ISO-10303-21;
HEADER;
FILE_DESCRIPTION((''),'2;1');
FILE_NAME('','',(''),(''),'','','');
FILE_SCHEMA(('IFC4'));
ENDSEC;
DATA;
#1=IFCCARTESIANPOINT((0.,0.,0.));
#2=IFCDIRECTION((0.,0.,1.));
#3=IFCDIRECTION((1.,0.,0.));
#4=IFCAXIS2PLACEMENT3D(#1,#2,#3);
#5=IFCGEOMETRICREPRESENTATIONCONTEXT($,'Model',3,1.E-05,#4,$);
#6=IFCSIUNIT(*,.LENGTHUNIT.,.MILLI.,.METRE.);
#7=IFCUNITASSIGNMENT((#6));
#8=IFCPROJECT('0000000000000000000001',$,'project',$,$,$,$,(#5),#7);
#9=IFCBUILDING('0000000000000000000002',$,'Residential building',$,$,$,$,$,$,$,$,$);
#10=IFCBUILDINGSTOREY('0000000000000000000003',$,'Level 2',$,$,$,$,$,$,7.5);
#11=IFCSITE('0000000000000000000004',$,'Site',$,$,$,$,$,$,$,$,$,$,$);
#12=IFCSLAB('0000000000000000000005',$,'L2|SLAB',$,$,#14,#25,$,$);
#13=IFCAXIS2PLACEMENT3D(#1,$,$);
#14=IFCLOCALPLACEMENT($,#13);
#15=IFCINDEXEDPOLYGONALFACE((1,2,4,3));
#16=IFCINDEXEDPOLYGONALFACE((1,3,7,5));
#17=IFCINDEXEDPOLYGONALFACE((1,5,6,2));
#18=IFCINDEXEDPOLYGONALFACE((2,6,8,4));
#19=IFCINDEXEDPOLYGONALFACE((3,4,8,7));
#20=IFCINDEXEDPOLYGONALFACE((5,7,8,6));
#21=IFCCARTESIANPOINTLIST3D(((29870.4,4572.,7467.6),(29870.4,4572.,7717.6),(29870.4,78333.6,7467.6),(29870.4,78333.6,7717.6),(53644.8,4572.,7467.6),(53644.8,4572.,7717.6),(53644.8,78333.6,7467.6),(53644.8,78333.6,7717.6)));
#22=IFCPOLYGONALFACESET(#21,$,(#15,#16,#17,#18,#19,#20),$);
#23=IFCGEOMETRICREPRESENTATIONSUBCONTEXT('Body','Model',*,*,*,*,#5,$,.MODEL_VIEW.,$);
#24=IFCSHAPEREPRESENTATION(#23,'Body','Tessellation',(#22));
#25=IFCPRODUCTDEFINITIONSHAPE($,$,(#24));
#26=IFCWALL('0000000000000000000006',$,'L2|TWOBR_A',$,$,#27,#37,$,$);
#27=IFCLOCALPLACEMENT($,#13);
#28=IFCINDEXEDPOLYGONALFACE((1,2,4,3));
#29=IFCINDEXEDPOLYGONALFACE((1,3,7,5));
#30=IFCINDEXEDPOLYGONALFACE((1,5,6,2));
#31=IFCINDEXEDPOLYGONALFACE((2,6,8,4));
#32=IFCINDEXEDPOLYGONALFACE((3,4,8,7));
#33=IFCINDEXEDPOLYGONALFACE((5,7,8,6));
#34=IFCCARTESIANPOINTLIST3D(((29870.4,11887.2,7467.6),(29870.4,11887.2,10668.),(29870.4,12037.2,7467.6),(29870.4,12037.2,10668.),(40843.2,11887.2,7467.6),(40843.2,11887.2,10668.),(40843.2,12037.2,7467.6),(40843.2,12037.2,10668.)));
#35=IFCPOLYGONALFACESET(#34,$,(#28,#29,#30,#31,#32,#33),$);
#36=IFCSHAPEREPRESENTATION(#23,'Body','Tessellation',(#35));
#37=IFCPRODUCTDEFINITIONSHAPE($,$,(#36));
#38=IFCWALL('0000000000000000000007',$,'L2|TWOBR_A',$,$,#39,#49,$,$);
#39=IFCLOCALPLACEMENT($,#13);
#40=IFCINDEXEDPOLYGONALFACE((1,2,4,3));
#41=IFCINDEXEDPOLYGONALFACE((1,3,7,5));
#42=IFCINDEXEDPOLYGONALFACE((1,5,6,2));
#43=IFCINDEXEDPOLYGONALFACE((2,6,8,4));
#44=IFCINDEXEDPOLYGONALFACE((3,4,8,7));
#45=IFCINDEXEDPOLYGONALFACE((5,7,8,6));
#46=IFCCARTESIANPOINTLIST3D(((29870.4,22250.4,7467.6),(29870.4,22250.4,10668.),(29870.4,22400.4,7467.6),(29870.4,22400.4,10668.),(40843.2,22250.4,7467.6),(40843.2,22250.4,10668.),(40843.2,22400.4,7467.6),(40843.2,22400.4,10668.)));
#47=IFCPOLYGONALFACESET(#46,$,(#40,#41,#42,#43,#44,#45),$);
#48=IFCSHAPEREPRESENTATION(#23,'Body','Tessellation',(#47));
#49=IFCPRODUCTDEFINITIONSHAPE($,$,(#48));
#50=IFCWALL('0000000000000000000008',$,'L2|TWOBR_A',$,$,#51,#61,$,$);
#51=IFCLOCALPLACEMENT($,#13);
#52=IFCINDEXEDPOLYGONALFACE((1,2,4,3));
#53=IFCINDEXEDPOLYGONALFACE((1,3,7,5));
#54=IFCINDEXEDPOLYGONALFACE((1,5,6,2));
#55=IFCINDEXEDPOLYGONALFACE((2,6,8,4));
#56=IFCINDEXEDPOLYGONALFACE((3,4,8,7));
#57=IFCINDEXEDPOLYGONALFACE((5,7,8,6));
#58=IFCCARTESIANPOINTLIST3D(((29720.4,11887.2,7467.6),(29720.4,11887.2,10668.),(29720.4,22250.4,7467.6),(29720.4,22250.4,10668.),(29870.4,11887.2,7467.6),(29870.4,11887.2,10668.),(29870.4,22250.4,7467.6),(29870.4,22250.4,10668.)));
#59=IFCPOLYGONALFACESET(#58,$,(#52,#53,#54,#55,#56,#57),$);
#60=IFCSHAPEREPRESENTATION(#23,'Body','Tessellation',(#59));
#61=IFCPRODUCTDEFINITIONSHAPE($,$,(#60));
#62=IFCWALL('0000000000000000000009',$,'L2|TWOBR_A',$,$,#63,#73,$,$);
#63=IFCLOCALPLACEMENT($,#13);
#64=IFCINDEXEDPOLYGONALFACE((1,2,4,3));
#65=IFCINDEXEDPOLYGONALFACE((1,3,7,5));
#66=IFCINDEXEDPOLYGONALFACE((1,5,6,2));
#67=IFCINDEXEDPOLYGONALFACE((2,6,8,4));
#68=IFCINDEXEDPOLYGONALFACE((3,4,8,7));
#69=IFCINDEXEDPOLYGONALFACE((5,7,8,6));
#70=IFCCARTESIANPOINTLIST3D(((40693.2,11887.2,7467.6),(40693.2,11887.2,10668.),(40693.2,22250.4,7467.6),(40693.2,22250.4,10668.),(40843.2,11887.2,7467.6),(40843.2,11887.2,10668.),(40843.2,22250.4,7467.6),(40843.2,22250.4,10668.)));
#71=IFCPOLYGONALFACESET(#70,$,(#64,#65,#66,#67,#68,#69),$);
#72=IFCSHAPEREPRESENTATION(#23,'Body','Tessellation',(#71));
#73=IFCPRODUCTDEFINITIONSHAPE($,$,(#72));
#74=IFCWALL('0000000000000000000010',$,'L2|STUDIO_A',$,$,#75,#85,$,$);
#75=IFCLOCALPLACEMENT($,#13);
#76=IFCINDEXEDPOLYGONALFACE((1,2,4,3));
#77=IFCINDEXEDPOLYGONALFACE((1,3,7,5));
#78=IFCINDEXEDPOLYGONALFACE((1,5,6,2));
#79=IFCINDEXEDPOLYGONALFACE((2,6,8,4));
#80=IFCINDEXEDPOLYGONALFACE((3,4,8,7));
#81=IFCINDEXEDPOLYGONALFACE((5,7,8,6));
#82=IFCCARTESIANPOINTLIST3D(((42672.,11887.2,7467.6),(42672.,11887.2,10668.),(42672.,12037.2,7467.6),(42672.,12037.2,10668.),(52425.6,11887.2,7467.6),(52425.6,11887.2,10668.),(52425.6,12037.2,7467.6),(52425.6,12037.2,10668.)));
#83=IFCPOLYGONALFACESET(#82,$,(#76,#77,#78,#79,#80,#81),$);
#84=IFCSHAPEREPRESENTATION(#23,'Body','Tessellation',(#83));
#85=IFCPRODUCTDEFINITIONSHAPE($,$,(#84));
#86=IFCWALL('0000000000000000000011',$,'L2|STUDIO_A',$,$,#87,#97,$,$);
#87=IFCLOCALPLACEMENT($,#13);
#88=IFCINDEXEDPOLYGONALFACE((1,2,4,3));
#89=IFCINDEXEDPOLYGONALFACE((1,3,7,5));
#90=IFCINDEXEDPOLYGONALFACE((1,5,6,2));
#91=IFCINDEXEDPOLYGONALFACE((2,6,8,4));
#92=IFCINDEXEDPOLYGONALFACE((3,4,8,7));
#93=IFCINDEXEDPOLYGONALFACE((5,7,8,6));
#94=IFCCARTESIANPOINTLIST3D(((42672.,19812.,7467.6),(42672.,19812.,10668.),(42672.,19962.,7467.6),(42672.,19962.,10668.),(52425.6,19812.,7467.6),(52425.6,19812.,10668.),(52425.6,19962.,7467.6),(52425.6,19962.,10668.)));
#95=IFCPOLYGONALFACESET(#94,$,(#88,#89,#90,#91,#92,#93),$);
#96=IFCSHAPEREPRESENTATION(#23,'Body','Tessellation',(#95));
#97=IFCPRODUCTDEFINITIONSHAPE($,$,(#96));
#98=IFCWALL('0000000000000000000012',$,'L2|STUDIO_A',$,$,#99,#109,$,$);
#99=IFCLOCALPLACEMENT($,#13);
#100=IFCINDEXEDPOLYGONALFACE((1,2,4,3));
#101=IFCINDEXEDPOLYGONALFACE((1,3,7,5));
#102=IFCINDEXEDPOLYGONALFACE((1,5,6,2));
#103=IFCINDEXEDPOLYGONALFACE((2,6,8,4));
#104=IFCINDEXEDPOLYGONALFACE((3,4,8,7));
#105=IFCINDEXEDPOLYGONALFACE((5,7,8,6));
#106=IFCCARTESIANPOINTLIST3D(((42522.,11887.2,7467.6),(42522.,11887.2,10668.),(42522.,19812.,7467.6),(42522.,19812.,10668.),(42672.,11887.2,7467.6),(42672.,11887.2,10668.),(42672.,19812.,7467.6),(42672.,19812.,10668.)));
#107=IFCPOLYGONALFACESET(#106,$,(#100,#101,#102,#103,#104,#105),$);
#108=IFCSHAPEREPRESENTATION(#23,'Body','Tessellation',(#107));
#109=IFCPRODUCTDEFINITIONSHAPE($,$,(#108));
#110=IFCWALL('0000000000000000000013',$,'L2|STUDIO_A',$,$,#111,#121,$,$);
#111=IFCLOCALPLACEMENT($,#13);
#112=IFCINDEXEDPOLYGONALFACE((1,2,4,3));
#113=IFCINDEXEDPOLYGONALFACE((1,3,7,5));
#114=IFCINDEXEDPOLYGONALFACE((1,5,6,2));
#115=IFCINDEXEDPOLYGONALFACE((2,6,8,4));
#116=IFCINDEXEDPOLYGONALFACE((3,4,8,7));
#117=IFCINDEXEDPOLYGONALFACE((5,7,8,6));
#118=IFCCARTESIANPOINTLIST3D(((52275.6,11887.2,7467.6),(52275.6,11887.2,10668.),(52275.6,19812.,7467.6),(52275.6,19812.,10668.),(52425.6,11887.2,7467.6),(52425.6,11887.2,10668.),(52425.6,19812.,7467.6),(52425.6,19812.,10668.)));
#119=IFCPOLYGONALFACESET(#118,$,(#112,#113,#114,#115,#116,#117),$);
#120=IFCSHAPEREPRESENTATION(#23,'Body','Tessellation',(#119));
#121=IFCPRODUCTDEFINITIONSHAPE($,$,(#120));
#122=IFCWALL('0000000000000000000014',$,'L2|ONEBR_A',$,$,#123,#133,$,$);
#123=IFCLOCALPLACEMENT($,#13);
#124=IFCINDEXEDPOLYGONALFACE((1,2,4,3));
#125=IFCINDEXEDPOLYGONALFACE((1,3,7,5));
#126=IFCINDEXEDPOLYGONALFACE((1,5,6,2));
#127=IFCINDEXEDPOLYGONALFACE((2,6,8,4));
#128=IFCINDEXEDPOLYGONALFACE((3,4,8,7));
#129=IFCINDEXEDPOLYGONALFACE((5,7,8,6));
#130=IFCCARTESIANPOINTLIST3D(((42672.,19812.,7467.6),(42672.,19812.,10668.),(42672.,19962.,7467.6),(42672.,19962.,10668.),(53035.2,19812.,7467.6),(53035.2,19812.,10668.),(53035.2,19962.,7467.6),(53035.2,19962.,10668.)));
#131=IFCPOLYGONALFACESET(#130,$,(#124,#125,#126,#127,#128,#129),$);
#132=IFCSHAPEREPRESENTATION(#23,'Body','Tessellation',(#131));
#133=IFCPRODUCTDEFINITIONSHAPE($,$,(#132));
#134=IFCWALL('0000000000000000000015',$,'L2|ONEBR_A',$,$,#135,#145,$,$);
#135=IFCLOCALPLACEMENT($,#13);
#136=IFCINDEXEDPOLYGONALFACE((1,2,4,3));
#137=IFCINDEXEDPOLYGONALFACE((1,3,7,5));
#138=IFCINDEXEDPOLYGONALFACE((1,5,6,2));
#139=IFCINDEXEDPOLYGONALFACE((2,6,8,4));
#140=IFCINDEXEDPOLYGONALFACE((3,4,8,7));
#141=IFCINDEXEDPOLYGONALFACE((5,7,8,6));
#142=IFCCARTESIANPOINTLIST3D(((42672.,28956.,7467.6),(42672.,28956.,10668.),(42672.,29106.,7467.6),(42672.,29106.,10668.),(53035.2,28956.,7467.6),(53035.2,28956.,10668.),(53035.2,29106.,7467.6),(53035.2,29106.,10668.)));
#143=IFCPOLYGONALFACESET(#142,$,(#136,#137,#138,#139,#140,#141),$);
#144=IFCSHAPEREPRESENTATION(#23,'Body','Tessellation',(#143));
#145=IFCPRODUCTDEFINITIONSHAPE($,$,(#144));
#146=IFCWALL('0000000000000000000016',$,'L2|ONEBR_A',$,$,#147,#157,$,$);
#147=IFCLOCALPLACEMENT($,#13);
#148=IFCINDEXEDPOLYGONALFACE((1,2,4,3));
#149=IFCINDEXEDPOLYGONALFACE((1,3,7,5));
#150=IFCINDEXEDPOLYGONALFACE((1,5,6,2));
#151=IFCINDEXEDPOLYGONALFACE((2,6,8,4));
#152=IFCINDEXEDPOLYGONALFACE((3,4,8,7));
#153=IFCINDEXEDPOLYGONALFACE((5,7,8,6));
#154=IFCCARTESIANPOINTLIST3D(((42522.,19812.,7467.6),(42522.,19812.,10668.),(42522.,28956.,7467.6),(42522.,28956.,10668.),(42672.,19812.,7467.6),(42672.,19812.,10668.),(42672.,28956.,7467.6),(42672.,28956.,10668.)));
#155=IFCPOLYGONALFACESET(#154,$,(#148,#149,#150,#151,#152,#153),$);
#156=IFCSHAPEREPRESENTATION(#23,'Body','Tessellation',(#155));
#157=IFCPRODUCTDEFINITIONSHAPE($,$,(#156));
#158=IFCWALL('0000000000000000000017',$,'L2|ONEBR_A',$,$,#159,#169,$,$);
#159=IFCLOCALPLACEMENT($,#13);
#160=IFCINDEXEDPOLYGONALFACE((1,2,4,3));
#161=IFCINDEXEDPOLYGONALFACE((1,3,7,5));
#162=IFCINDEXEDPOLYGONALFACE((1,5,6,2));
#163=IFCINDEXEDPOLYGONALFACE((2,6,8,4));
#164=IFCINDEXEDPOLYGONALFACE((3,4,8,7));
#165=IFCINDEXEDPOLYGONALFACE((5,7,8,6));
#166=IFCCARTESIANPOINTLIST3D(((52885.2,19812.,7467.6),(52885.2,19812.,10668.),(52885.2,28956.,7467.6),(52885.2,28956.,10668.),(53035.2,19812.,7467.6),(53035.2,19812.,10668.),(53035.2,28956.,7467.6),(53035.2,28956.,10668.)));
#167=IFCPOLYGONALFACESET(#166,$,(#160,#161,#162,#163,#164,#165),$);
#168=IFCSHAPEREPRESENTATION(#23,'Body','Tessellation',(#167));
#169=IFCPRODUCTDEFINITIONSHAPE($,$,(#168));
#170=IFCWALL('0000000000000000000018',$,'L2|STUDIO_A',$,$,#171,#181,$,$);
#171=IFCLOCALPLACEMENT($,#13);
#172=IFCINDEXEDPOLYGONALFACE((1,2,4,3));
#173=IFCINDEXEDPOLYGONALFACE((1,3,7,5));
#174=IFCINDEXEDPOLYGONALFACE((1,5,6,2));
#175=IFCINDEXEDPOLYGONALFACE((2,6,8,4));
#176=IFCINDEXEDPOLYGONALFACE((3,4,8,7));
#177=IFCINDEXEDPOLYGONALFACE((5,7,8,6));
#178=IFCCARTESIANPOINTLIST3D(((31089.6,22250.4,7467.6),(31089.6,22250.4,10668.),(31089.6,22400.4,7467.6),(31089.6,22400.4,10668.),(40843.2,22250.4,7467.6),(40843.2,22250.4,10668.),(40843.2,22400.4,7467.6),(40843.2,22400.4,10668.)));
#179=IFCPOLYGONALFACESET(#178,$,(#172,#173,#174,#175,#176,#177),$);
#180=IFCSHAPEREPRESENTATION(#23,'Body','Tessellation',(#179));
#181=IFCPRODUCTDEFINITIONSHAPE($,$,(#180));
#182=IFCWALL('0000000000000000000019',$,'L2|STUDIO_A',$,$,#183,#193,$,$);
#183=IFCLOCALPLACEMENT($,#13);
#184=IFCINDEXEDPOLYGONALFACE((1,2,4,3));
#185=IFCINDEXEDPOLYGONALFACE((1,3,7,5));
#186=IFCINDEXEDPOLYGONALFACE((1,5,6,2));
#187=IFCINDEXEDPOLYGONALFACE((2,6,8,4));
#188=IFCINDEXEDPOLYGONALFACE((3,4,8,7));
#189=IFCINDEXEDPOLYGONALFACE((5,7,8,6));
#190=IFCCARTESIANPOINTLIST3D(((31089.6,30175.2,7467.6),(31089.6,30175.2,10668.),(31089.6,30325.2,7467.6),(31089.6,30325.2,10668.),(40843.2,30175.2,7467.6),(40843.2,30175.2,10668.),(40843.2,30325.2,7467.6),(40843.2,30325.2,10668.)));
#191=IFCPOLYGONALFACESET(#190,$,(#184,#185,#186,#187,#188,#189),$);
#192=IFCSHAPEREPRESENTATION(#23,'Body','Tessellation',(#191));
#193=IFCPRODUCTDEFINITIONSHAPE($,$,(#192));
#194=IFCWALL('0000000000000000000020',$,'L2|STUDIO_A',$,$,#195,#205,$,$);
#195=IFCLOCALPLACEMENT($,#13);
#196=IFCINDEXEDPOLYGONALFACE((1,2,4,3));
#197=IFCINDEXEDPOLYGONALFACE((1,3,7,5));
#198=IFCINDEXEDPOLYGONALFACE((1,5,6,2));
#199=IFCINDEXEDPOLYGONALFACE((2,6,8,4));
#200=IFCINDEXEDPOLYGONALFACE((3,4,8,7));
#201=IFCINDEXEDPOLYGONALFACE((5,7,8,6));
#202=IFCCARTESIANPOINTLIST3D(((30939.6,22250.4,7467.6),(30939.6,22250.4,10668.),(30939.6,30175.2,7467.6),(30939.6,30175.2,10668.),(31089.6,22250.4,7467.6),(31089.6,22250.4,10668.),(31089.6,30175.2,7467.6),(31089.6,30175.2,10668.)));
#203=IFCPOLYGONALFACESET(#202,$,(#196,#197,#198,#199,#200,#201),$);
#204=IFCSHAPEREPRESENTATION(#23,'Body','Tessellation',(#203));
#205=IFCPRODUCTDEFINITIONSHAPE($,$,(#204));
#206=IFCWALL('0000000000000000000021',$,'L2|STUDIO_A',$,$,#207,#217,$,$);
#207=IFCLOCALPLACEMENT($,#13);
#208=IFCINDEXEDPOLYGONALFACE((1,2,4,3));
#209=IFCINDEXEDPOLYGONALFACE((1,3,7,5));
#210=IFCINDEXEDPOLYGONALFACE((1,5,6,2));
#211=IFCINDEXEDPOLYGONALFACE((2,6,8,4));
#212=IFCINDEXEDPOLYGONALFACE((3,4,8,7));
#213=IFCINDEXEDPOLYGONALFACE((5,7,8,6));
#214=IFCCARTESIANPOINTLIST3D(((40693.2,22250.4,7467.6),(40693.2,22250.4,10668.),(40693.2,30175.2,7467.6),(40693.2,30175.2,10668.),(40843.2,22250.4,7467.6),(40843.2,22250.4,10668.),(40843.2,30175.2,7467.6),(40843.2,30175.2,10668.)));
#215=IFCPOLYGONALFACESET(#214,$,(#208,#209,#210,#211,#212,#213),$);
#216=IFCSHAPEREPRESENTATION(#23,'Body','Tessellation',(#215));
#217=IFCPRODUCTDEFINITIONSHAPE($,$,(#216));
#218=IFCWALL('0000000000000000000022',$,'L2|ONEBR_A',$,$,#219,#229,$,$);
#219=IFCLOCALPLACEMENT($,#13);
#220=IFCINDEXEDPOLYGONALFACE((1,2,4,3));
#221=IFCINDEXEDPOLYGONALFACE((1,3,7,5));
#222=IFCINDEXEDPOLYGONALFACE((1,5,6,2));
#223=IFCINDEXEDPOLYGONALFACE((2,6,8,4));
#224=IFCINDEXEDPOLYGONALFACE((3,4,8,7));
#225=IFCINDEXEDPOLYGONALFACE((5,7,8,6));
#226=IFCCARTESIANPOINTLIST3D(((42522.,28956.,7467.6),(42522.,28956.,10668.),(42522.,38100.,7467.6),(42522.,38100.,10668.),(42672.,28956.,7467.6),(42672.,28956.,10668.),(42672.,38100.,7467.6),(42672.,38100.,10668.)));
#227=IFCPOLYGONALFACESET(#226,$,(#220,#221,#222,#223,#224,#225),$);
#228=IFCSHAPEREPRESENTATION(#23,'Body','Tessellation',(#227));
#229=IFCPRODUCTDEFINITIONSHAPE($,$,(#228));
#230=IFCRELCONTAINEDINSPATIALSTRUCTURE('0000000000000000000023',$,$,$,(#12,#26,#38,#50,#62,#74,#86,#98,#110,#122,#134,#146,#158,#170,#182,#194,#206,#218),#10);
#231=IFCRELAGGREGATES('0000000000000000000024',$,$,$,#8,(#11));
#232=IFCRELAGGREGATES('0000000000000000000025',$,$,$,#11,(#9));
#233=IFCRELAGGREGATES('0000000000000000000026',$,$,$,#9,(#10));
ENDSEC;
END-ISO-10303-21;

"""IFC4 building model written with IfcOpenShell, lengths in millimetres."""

from ifc_helpers import new_model, si_unit, frame, origin_with_axes, place, context, subcontext, project, spatial, indexed_curve, outline, extrude, element, save


model = new_model("IFC4")

# Units and contexts
model_context = context("Model", 3, precision=1e-05, world=origin_with_axes())
body_context = subcontext(model_context, "Body", "Model", "MODEL_VIEW")
ifc_project = project(units=[si_unit("LENGTHUNIT", "METRE", prefix="MILLI")], contexts=[model_context])

# Site, building, storey
site = spatial("IfcSite", under=ifc_project, Name="Site")
building = spatial("IfcBuilding", under=site, Name="Residential building")
storey = spatial("IfcBuildingStorey", under=building, Name="Level 2", Elevation=7.5)

# Slab
slab_placement = place(None, frame((29870.4, 4572.0, 7467.6), z_axis=(0.0, 0.0, 1.0), x_axis=(1.0, 0.0, 0.0)))
element("IfcSlab", 1, at=slab_placement, inside=storey, Name="L2|SLAB", context=body_context, shape_type="SweptSolid", body=[
    extrude(outline(indexed_curve([(0.0, 0.0), (23774.4, 0.0), (23774.4, 73761.6), (0.0, 73761.6), (0.0, 0.0)])), None, (0.0, 0.0, 1.0), 250.0),
])

# Walls
for number, where, z_axis, x_axis, name in (
    (2, (29870.4, 11887.2, 7467.6), (0.0, 0.0, 1.0), (1.0, 0.0, 0.0), "L2|TWOBR_A"),
    (3, (29870.4, 22250.4, 7467.6), (0.0, 0.0, 1.0), (1.0, 0.0, 0.0), "L2|TWOBR_A"),
):
    element("IfcWall", number, at=place(None, frame(where, z_axis=z_axis, x_axis=x_axis)), inside=storey, Name=name, context=body_context, shape_type="SweptSolid", body=[
        extrude(outline(indexed_curve([(0.0, 0.0), (0.0, 150.0), (10972.8, 150.0), (10972.8, 0.0), (0.0, 0.0)], self_intersect=False)), origin_with_axes(), (0.0, 0.0, 1.0), 3200.4),
    ])
for number, where, z_axis, x_axis, name in (
    (4, (29870.4, 11887.2, 7467.6), (0.0, 0.0, 1.0), (0.0, 1.0, 0.0), "L2|TWOBR_A"),
    (5, (40843.2, 11887.2, 7467.6), (0.0, 0.0, 1.0), (0.0, 1.0, 0.0), "L2|TWOBR_A"),
):
    element("IfcWall", number, at=place(None, frame(where, z_axis=z_axis, x_axis=x_axis)), inside=storey, Name=name, context=body_context, shape_type="SweptSolid", body=[
        extrude(outline(indexed_curve([(0.0, 0.0), (0.0, 150.0), (10363.2, 150.0), (10363.2, 0.0), (0.0, 0.0)], self_intersect=False)), origin_with_axes(), (0.0, 0.0, 1.0), 3200.4),
    ])
for number, where, z_axis, x_axis, name in (
    (6, (42672.0, 11887.2, 7467.6), (0.0, 0.0, 1.0), (1.0, 0.0, 0.0), "L2|STUDIO_A"),
    (7, (42672.0, 19812.0, 7467.6), (0.0, 0.0, 1.0), (1.0, 0.0, 0.0), "L2|STUDIO_A"),
):
    element("IfcWall", number, at=place(None, frame(where, z_axis=z_axis, x_axis=x_axis)), inside=storey, Name=name, context=body_context, shape_type="SweptSolid", body=[
        extrude(outline(indexed_curve([(0.0, 0.0), (0.0, 150.0), (9753.6, 150.0), (9753.6, 0.0), (0.0, 0.0)], self_intersect=False)), origin_with_axes(), (0.0, 0.0, 1.0), 3200.4),
    ])
for number, where, z_axis, x_axis, name in (
    (8, (42672.0, 11887.2, 7467.6), (0.0, 0.0, 1.0), (0.0, 1.0, 0.0), "L2|STUDIO_A"),
    (9, (52425.6, 11887.2, 7467.6), (0.0, 0.0, 1.0), (0.0, 1.0, 0.0), "L2|STUDIO_A"),
):
    element("IfcWall", number, at=place(None, frame(where, z_axis=z_axis, x_axis=x_axis)), inside=storey, Name=name, context=body_context, shape_type="SweptSolid", body=[
        extrude(outline(indexed_curve([(0.0, 0.0), (0.0, 150.0), (7924.8, 150.0), (7924.8, 0.0), (0.0, 0.0)], self_intersect=False)), origin_with_axes(), (0.0, 0.0, 1.0), 3200.4),
    ])
for number, where, z_axis, x_axis, name in (
    (10, (42672.0, 19812.0, 7467.6), (0.0, 0.0, 1.0), (1.0, 0.0, 0.0), "L2|ONEBR_A"),
    (11, (42672.0, 28956.0, 7467.6), (0.0, 0.0, 1.0), (1.0, 0.0, 0.0), "L2|ONEBR_A"),
):
    element("IfcWall", number, at=place(None, frame(where, z_axis=z_axis, x_axis=x_axis)), inside=storey, Name=name, context=body_context, shape_type="SweptSolid", body=[
        extrude(outline(indexed_curve([(0.0, 0.0), (0.0, 150.0), (10363.2, 150.0), (10363.2, 0.0), (0.0, 0.0)], self_intersect=False)), origin_with_axes(), (0.0, 0.0, 1.0), 3200.4),
    ])
for number, where, z_axis, x_axis, name in (
    (12, (42672.0, 19812.0, 7467.6), (0.0, 0.0, 1.0), (0.0, 1.0, 0.0), "L2|ONEBR_A"),
    (13, (53035.2, 19812.0, 7467.6), (0.0, 0.0, 1.0), (0.0, 1.0, 0.0), "L2|ONEBR_A"),
):
    element("IfcWall", number, at=place(None, frame(where, z_axis=z_axis, x_axis=x_axis)), inside=storey, Name=name, context=body_context, shape_type="SweptSolid", body=[
        extrude(outline(indexed_curve([(0.0, 0.0), (0.0, 150.0), (9144.0, 150.0), (9144.0, 0.0), (0.0, 0.0)], self_intersect=False)), origin_with_axes(), (0.0, 0.0, 1.0), 3200.4),
    ])
for number, where, z_axis, x_axis, name in (
    (14, (31089.6, 22250.4, 7467.6), (0.0, 0.0, 1.0), (1.0, 0.0, 0.0), "L2|STUDIO_A"),
    (15, (31089.6, 30175.2, 7467.6), (0.0, 0.0, 1.0), (1.0, 0.0, 0.0), "L2|STUDIO_A"),
):
    element("IfcWall", number, at=place(None, frame(where, z_axis=z_axis, x_axis=x_axis)), inside=storey, Name=name, context=body_context, shape_type="SweptSolid", body=[
        extrude(outline(indexed_curve([(0.0, 0.0), (0.0, 150.0), (9753.6, 150.0), (9753.6, 0.0), (0.0, 0.0)], self_intersect=False)), origin_with_axes(), (0.0, 0.0, 1.0), 3200.4),
    ])
for number, where, z_axis, x_axis, name in (
    (16, (31089.6, 22250.4, 7467.6), (0.0, 0.0, 1.0), (0.0, 1.0, 0.0), "L2|STUDIO_A"),
    (17, (40843.2, 22250.4, 7467.6), (0.0, 0.0, 1.0), (0.0, 1.0, 0.0), "L2|STUDIO_A"),
):
    element("IfcWall", number, at=place(None, frame(where, z_axis=z_axis, x_axis=x_axis)), inside=storey, Name=name, context=body_context, shape_type="SweptSolid", body=[
        extrude(outline(indexed_curve([(0.0, 0.0), (0.0, 150.0), (7924.8, 150.0), (7924.8, 0.0), (0.0, 0.0)], self_intersect=False)), origin_with_axes(), (0.0, 0.0, 1.0), 3200.4),
    ])
for number, where, z_axis, x_axis, name in (
    (18, (42672.0, 28956.0, 7467.6), (0.0, 0.0, 1.0), (0.0, 1.0, 0.0), "L2|ONEBR_A"),
):
    element("IfcWall", number, at=place(None, frame(where, z_axis=z_axis, x_axis=x_axis)), inside=storey, Name=name, context=body_context, shape_type="SweptSolid", body=[
        extrude(outline(indexed_curve([(0.0, 0.0), (0.0, 150.0), (9144.0, 150.0), (9144.0, 0.0), (0.0, 0.0)], self_intersect=False)), origin_with_axes(), (0.0, 0.0, 1.0), 3200.4),
    ])

save(model, "model.ifc")
